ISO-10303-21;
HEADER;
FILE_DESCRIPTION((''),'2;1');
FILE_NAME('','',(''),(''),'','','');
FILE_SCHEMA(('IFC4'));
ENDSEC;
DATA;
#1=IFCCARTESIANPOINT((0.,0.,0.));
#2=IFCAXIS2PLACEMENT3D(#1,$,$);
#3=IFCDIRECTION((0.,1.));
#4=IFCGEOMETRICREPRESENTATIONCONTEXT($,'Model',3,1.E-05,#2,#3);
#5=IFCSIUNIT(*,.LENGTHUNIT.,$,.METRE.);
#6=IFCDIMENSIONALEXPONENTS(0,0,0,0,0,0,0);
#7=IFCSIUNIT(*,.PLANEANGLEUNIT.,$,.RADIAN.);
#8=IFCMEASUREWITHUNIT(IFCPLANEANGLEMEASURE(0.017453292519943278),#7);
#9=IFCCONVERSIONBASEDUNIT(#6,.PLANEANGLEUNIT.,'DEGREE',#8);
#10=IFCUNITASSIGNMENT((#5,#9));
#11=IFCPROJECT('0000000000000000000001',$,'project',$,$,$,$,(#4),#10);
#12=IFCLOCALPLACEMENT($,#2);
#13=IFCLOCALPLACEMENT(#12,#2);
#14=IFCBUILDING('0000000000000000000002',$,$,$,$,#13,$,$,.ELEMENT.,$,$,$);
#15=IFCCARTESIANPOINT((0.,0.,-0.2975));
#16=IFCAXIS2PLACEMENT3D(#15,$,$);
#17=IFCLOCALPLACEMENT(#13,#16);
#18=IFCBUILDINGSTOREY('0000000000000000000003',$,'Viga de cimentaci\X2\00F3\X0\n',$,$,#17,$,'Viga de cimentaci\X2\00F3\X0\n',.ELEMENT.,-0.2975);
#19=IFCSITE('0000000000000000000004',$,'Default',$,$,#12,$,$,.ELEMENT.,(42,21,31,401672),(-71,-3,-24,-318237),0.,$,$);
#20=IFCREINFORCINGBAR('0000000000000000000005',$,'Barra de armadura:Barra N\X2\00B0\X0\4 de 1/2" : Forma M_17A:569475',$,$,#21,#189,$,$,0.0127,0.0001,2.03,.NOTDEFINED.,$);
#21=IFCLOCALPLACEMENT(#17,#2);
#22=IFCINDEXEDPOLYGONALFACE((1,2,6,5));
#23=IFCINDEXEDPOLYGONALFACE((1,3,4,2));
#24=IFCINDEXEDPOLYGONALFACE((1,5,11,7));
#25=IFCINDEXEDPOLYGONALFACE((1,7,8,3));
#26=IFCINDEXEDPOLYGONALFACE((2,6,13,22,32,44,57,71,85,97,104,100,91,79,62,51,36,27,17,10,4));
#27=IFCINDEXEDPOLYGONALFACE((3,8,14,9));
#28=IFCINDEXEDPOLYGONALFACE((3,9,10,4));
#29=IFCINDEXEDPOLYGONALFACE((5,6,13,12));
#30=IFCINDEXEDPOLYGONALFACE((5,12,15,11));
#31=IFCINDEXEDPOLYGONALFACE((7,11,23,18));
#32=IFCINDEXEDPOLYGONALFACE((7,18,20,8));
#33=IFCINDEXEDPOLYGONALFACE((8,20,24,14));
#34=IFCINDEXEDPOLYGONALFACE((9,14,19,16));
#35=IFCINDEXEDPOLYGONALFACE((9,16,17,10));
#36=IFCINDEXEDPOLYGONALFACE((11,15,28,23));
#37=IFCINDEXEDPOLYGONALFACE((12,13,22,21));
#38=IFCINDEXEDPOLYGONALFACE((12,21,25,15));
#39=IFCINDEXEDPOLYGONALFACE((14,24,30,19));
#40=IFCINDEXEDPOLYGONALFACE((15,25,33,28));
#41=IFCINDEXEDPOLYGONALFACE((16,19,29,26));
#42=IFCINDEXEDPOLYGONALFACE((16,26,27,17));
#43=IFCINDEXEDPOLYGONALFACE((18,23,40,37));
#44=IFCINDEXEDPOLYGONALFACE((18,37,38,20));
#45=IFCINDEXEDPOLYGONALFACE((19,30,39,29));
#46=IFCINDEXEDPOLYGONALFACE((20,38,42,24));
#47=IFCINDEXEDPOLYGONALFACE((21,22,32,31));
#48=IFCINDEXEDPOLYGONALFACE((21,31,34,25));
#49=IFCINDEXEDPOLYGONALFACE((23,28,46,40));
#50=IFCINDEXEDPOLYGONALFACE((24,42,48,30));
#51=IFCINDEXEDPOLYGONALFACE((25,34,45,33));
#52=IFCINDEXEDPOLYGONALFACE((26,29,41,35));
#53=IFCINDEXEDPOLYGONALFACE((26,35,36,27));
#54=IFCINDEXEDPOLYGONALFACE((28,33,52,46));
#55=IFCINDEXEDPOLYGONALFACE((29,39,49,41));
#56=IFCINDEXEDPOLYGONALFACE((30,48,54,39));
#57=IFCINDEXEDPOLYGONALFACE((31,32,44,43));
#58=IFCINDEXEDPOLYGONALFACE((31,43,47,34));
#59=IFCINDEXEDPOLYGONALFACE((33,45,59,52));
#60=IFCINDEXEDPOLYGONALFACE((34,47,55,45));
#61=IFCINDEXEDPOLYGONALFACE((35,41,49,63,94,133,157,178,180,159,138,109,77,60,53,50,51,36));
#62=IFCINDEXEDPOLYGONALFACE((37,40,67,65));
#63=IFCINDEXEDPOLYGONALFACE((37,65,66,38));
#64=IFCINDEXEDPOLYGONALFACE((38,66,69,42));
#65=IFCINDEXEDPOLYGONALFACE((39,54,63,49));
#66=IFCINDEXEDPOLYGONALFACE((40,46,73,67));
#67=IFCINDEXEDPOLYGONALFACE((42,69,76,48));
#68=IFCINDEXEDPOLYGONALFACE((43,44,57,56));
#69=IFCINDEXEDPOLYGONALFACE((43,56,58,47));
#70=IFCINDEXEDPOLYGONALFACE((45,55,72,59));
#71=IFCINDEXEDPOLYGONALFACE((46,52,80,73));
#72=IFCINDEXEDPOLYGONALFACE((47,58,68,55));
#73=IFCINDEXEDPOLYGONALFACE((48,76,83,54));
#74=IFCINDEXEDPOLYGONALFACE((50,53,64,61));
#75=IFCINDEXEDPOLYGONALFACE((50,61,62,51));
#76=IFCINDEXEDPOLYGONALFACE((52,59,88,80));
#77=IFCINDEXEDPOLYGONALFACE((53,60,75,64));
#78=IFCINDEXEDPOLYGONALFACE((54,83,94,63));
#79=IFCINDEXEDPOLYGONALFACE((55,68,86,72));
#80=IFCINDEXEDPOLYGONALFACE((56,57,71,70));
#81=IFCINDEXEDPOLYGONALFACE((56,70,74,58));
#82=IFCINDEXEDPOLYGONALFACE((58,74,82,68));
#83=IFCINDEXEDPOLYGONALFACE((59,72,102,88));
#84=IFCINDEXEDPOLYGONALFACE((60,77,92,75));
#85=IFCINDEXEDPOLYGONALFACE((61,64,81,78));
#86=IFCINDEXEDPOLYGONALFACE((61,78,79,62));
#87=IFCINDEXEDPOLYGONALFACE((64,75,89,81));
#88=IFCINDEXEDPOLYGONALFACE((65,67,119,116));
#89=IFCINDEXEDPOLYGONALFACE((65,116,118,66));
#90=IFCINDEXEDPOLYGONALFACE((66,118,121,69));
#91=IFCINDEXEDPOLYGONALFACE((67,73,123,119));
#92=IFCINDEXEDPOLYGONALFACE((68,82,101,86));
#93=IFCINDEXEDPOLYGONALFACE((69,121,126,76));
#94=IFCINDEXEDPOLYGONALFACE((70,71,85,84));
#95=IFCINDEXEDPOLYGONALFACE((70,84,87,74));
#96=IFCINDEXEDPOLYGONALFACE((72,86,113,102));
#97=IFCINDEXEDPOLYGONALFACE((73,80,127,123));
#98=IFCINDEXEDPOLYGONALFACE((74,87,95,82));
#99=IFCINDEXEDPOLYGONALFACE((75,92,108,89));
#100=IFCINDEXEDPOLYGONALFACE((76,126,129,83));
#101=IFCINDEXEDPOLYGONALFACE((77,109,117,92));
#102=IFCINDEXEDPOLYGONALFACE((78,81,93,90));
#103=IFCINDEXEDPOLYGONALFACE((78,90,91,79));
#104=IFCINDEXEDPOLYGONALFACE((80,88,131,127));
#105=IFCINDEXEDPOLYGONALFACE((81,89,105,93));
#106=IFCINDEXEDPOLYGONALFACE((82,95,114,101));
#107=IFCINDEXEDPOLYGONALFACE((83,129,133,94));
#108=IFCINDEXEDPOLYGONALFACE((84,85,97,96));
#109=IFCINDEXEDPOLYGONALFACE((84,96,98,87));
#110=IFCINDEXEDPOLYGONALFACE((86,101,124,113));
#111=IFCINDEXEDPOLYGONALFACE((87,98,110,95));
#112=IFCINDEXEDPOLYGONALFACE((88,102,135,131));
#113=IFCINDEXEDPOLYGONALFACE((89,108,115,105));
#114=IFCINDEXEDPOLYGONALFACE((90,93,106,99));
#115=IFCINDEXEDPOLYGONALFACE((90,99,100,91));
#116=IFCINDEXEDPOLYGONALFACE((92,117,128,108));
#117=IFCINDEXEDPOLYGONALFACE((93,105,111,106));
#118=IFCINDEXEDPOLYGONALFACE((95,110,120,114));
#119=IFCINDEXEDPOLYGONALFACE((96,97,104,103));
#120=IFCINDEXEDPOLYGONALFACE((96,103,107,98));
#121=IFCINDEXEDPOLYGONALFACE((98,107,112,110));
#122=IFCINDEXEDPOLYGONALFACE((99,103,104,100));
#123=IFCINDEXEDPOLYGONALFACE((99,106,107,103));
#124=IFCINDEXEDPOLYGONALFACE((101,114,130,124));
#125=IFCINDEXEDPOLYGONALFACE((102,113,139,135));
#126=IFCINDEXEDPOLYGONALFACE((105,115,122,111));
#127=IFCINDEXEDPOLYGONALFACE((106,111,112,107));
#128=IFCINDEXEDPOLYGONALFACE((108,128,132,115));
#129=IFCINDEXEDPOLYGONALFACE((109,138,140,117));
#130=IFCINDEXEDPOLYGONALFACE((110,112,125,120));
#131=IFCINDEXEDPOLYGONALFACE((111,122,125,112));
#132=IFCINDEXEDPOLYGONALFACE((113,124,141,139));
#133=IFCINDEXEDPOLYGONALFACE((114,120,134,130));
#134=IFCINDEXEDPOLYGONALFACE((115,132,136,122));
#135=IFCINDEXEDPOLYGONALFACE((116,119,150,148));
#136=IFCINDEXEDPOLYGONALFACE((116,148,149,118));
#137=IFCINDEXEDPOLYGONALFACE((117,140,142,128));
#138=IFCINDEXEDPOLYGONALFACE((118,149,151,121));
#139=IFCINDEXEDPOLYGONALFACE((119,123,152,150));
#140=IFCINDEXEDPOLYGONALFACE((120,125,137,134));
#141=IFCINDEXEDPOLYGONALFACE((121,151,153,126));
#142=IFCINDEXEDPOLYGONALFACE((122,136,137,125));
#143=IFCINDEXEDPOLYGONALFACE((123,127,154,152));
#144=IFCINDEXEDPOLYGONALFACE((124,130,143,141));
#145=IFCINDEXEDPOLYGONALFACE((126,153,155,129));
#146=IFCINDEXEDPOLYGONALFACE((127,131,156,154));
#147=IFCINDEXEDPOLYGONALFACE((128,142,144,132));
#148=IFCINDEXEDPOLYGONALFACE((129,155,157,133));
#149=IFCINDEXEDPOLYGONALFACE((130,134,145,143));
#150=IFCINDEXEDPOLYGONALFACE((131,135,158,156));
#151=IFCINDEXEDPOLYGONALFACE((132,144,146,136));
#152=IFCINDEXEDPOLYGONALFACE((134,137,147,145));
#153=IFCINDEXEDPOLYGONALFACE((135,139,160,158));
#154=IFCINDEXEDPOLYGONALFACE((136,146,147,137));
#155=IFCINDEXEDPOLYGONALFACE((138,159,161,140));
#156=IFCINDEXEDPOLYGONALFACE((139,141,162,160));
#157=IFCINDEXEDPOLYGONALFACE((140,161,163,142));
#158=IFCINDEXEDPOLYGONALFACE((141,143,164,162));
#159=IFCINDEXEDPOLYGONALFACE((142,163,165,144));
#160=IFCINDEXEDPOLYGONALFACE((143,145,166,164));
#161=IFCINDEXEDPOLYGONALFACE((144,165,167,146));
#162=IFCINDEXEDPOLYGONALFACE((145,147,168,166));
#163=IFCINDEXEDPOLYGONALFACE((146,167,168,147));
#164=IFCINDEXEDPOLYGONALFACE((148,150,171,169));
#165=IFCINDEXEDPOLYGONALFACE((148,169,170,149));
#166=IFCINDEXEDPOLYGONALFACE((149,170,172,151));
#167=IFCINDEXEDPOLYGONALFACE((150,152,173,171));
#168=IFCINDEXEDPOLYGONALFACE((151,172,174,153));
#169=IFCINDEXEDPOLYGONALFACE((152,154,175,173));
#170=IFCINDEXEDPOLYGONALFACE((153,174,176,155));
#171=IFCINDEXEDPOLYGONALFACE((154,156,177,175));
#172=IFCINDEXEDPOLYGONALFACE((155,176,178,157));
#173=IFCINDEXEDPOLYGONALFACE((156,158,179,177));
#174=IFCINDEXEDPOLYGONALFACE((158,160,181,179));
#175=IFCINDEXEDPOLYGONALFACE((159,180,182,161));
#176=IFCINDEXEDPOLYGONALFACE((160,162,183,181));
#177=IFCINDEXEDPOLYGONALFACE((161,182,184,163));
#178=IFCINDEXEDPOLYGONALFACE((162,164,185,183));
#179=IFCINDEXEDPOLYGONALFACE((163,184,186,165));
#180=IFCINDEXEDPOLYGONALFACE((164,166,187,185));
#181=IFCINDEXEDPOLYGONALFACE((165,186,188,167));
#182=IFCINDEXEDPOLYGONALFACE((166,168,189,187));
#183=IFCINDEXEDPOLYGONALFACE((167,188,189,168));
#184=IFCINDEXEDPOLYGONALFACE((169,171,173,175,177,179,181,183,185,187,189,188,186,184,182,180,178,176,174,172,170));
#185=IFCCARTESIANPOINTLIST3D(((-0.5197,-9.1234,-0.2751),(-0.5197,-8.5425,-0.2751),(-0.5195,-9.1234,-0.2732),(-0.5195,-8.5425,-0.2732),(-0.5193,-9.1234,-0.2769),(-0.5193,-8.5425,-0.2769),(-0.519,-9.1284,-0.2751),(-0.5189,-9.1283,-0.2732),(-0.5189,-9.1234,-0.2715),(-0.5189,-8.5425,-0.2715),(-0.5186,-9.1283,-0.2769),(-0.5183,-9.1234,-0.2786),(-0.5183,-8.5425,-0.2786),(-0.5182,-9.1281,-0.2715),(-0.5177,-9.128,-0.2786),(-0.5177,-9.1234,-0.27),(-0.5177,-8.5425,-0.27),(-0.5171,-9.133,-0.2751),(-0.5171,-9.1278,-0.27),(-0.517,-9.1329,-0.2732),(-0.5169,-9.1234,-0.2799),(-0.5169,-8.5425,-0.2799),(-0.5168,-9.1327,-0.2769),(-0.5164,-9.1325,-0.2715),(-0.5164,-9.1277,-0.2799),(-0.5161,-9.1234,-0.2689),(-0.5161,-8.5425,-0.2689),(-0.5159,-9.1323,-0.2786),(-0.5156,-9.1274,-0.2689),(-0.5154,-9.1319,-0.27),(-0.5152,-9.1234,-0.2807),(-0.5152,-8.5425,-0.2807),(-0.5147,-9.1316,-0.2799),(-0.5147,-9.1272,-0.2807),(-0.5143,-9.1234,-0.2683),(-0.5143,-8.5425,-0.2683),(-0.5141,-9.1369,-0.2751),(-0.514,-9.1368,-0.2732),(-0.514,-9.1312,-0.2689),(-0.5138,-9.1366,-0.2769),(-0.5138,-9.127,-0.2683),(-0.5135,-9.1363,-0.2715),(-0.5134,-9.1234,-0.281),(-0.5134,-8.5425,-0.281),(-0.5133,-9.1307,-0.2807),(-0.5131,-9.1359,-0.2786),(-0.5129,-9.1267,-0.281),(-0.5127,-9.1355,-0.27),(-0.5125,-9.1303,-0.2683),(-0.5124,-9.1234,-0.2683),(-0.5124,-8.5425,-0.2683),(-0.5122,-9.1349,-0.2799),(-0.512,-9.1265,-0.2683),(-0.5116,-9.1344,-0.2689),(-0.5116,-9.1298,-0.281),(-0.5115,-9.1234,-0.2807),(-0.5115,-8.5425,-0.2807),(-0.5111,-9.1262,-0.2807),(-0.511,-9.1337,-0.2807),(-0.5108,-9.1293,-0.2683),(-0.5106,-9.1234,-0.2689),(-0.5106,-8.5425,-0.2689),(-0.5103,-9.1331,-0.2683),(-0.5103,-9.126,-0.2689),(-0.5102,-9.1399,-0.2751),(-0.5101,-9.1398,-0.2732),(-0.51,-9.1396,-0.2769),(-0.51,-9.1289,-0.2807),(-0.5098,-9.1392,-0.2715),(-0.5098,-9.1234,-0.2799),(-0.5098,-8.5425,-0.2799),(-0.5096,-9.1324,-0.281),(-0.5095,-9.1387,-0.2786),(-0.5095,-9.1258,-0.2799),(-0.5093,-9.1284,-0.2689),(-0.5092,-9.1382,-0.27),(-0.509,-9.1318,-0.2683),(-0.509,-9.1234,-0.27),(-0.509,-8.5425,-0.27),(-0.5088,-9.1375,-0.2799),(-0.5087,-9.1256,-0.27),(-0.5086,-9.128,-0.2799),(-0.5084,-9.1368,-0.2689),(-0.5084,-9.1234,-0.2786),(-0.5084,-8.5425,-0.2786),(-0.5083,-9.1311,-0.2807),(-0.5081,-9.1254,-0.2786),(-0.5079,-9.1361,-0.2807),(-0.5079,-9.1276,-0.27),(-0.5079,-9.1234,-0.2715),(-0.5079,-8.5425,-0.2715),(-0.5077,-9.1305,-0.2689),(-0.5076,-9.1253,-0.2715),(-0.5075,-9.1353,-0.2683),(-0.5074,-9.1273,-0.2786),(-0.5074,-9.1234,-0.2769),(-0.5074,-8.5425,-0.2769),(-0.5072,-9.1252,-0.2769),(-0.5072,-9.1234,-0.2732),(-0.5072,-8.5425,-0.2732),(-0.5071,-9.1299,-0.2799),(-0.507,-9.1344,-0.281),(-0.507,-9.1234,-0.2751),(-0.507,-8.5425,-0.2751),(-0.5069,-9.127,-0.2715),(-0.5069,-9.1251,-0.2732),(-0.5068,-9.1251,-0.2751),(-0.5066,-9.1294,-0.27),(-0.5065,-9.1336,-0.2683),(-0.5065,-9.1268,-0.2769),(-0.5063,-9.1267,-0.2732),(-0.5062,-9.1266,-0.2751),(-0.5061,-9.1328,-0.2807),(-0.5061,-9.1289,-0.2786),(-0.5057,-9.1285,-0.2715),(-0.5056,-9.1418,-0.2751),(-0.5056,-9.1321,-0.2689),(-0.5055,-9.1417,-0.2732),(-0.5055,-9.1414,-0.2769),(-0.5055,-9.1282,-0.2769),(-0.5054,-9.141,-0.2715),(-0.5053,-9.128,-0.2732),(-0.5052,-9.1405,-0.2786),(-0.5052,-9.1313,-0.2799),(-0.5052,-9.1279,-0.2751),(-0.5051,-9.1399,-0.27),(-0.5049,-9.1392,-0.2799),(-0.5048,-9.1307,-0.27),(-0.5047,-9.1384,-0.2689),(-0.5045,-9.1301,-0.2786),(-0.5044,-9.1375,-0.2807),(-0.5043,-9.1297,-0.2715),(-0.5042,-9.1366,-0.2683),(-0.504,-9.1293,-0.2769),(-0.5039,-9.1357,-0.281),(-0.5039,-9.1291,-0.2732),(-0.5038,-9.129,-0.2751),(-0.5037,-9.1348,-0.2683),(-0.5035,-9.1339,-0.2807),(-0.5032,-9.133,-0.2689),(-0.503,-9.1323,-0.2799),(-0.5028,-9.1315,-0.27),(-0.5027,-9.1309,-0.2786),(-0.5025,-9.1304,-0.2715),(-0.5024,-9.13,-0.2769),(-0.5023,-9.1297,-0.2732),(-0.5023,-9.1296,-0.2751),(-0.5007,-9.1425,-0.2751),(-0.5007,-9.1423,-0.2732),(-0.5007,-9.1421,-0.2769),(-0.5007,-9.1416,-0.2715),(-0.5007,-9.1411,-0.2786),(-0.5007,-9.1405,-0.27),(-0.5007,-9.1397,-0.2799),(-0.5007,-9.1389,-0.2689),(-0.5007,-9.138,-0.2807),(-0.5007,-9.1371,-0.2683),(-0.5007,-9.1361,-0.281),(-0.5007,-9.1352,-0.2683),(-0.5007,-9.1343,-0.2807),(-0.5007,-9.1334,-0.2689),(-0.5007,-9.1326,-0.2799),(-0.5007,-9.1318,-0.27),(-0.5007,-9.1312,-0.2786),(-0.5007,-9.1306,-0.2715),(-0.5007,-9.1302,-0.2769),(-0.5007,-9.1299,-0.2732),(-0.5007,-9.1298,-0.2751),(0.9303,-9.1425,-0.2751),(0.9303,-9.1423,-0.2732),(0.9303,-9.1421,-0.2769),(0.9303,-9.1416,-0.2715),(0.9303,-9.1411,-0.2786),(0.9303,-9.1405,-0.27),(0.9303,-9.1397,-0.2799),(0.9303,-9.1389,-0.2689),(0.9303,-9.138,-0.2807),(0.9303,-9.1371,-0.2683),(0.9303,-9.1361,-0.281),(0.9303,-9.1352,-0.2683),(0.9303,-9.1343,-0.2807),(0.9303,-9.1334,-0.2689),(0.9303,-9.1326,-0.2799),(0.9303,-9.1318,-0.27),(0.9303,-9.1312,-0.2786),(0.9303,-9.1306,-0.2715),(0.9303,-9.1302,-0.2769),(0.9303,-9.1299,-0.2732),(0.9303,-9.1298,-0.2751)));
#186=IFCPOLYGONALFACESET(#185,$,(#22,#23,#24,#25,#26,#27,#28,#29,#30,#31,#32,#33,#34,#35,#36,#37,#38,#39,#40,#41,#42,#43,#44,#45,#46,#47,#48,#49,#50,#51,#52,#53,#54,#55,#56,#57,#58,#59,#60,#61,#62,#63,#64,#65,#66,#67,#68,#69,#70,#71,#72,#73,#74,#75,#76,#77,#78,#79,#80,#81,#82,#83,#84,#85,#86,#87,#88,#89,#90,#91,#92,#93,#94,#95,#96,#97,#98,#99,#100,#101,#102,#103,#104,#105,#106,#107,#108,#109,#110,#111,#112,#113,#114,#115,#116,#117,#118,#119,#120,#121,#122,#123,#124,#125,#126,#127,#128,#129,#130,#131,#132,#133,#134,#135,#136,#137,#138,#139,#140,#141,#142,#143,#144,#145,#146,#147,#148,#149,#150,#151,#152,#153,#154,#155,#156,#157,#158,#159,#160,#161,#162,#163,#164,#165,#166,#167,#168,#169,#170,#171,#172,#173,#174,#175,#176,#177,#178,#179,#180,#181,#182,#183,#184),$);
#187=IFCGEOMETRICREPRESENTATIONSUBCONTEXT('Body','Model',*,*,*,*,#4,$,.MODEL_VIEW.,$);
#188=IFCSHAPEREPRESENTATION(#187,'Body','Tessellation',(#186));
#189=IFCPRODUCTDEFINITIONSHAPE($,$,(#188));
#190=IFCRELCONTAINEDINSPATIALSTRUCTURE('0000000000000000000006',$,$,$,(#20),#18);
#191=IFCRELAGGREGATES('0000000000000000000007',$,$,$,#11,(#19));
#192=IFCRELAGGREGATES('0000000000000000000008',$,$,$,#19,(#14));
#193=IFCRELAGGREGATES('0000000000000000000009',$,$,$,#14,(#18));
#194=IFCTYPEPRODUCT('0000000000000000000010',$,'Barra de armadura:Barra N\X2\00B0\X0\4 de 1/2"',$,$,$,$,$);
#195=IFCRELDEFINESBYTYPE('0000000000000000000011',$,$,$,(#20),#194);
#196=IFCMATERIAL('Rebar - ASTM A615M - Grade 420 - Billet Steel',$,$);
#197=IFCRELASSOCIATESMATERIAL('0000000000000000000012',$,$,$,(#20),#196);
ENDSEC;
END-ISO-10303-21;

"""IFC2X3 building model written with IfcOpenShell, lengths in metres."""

from ifc_helpers import new_model, entity, si_unit, converted_unit, direction, frame, origin, place, context, subcontext, project, spatial, material, type_object, element, save


model = new_model("IFC2X3")

# Units and contexts
model_context = context("Model", 3, precision=1e-05, world=origin(), true_north=direction((0.0, 1.0)))
body_context = subcontext(model_context, "Body", "Model", "MODEL_VIEW")
ifc_project = project(units=[si_unit("LENGTHUNIT", "METRE"), converted_unit("PLANEANGLEUNIT", "DEGREE", entity("IfcPlaneAngleMeasure", 0.017453292519943278), si_unit("PLANEANGLEUNIT", "RADIAN"), dimensions=[0, 0, 0, 0, 0, 0, 0])], contexts=[model_context])

# Site, building, storey
site_placement = place(None, origin())
site = spatial("IfcSite", under=ifc_project, at=site_placement, Name="Default", CompositionType="ELEMENT", RefLatitude=(42, 21, 31, 401672), RefLongitude=(-71, -3, -24, -318237), RefElevation=0.0)
building_placement = place(site_placement, origin())
building = spatial("IfcBuilding", under=site, at=building_placement, CompositionType="ELEMENT")
storey_placement = place(building_placement, frame((0.0, 0.0, -0.2975)))
storey = spatial("IfcBuildingStorey", under=building, at=storey_placement, Name="Viga de cimentación", LongName="Viga de cimentación", CompositionType="ELEMENT", Elevation=-0.2975)

# Reinforcing bar
ifc_material = material(Name="Rebar - ASTM A615M - Grade 420 - Billet Steel")
type_product_1 = type_object("IfcTypeProduct", Name="Barra de armadura:Barra N°4 de 1/2\"")
reinforcing_bar_1_placement = place(storey_placement, origin())
element("IfcReinforcingBar", 1, at=reinforcing_bar_1_placement, inside=storey, type_object=type_product_1, material=ifc_material, Name="Barra de armadura:Barra N°4 de 1/2\" : Forma M_17A:569475", BarLength=2.03, BarRole="NOTDEFINED", CrossSectionArea=0.0001, NominalDiameter=0.0127, context=body_context, shape_type="AdvancedSweptSolid", body=[
    entity("IfcSweptDiskSolid", entity("IfcCompositeCurve", [entity("IfcCompositeCurveSegment", "CONTINUOUS", True, entity("IfcPolyline", [entity("IfcCartesianPoint", [-0.5134, -8.5425, -0.2746]), entity("IfcCartesianPoint", [-0.5134, -9.1234, -0.2746])])), entity("IfcCompositeCurveSegment", "CONTINUOUS", True, entity("IfcTrimmedCurve", entity("IfcCircle", entity("IfcAxis2Placement3D", entity("IfcCartesianPoint", [-0.5007, -9.1234, -0.2746]), entity("IfcDirection", [0.0, 0.0, 1.0]), entity("IfcDirection", [0.0, -1.0, 0.0])), 0.0127), [entity("IfcParameterValue", 270.0)], [entity("IfcParameterValue", 360.0)], True, "PARAMETER")), entity("IfcCompositeCurveSegment", "CONTINUOUS", True, entity("IfcPolyline", [entity("IfcCartesianPoint", [-0.5007, -9.1361, -0.2746]), entity("IfcCartesianPoint", [0.9303, -9.1361, -0.2746])]))], False), 0.0063, None, 0.0, 92.0),
])

save(model, "model.ifc")
